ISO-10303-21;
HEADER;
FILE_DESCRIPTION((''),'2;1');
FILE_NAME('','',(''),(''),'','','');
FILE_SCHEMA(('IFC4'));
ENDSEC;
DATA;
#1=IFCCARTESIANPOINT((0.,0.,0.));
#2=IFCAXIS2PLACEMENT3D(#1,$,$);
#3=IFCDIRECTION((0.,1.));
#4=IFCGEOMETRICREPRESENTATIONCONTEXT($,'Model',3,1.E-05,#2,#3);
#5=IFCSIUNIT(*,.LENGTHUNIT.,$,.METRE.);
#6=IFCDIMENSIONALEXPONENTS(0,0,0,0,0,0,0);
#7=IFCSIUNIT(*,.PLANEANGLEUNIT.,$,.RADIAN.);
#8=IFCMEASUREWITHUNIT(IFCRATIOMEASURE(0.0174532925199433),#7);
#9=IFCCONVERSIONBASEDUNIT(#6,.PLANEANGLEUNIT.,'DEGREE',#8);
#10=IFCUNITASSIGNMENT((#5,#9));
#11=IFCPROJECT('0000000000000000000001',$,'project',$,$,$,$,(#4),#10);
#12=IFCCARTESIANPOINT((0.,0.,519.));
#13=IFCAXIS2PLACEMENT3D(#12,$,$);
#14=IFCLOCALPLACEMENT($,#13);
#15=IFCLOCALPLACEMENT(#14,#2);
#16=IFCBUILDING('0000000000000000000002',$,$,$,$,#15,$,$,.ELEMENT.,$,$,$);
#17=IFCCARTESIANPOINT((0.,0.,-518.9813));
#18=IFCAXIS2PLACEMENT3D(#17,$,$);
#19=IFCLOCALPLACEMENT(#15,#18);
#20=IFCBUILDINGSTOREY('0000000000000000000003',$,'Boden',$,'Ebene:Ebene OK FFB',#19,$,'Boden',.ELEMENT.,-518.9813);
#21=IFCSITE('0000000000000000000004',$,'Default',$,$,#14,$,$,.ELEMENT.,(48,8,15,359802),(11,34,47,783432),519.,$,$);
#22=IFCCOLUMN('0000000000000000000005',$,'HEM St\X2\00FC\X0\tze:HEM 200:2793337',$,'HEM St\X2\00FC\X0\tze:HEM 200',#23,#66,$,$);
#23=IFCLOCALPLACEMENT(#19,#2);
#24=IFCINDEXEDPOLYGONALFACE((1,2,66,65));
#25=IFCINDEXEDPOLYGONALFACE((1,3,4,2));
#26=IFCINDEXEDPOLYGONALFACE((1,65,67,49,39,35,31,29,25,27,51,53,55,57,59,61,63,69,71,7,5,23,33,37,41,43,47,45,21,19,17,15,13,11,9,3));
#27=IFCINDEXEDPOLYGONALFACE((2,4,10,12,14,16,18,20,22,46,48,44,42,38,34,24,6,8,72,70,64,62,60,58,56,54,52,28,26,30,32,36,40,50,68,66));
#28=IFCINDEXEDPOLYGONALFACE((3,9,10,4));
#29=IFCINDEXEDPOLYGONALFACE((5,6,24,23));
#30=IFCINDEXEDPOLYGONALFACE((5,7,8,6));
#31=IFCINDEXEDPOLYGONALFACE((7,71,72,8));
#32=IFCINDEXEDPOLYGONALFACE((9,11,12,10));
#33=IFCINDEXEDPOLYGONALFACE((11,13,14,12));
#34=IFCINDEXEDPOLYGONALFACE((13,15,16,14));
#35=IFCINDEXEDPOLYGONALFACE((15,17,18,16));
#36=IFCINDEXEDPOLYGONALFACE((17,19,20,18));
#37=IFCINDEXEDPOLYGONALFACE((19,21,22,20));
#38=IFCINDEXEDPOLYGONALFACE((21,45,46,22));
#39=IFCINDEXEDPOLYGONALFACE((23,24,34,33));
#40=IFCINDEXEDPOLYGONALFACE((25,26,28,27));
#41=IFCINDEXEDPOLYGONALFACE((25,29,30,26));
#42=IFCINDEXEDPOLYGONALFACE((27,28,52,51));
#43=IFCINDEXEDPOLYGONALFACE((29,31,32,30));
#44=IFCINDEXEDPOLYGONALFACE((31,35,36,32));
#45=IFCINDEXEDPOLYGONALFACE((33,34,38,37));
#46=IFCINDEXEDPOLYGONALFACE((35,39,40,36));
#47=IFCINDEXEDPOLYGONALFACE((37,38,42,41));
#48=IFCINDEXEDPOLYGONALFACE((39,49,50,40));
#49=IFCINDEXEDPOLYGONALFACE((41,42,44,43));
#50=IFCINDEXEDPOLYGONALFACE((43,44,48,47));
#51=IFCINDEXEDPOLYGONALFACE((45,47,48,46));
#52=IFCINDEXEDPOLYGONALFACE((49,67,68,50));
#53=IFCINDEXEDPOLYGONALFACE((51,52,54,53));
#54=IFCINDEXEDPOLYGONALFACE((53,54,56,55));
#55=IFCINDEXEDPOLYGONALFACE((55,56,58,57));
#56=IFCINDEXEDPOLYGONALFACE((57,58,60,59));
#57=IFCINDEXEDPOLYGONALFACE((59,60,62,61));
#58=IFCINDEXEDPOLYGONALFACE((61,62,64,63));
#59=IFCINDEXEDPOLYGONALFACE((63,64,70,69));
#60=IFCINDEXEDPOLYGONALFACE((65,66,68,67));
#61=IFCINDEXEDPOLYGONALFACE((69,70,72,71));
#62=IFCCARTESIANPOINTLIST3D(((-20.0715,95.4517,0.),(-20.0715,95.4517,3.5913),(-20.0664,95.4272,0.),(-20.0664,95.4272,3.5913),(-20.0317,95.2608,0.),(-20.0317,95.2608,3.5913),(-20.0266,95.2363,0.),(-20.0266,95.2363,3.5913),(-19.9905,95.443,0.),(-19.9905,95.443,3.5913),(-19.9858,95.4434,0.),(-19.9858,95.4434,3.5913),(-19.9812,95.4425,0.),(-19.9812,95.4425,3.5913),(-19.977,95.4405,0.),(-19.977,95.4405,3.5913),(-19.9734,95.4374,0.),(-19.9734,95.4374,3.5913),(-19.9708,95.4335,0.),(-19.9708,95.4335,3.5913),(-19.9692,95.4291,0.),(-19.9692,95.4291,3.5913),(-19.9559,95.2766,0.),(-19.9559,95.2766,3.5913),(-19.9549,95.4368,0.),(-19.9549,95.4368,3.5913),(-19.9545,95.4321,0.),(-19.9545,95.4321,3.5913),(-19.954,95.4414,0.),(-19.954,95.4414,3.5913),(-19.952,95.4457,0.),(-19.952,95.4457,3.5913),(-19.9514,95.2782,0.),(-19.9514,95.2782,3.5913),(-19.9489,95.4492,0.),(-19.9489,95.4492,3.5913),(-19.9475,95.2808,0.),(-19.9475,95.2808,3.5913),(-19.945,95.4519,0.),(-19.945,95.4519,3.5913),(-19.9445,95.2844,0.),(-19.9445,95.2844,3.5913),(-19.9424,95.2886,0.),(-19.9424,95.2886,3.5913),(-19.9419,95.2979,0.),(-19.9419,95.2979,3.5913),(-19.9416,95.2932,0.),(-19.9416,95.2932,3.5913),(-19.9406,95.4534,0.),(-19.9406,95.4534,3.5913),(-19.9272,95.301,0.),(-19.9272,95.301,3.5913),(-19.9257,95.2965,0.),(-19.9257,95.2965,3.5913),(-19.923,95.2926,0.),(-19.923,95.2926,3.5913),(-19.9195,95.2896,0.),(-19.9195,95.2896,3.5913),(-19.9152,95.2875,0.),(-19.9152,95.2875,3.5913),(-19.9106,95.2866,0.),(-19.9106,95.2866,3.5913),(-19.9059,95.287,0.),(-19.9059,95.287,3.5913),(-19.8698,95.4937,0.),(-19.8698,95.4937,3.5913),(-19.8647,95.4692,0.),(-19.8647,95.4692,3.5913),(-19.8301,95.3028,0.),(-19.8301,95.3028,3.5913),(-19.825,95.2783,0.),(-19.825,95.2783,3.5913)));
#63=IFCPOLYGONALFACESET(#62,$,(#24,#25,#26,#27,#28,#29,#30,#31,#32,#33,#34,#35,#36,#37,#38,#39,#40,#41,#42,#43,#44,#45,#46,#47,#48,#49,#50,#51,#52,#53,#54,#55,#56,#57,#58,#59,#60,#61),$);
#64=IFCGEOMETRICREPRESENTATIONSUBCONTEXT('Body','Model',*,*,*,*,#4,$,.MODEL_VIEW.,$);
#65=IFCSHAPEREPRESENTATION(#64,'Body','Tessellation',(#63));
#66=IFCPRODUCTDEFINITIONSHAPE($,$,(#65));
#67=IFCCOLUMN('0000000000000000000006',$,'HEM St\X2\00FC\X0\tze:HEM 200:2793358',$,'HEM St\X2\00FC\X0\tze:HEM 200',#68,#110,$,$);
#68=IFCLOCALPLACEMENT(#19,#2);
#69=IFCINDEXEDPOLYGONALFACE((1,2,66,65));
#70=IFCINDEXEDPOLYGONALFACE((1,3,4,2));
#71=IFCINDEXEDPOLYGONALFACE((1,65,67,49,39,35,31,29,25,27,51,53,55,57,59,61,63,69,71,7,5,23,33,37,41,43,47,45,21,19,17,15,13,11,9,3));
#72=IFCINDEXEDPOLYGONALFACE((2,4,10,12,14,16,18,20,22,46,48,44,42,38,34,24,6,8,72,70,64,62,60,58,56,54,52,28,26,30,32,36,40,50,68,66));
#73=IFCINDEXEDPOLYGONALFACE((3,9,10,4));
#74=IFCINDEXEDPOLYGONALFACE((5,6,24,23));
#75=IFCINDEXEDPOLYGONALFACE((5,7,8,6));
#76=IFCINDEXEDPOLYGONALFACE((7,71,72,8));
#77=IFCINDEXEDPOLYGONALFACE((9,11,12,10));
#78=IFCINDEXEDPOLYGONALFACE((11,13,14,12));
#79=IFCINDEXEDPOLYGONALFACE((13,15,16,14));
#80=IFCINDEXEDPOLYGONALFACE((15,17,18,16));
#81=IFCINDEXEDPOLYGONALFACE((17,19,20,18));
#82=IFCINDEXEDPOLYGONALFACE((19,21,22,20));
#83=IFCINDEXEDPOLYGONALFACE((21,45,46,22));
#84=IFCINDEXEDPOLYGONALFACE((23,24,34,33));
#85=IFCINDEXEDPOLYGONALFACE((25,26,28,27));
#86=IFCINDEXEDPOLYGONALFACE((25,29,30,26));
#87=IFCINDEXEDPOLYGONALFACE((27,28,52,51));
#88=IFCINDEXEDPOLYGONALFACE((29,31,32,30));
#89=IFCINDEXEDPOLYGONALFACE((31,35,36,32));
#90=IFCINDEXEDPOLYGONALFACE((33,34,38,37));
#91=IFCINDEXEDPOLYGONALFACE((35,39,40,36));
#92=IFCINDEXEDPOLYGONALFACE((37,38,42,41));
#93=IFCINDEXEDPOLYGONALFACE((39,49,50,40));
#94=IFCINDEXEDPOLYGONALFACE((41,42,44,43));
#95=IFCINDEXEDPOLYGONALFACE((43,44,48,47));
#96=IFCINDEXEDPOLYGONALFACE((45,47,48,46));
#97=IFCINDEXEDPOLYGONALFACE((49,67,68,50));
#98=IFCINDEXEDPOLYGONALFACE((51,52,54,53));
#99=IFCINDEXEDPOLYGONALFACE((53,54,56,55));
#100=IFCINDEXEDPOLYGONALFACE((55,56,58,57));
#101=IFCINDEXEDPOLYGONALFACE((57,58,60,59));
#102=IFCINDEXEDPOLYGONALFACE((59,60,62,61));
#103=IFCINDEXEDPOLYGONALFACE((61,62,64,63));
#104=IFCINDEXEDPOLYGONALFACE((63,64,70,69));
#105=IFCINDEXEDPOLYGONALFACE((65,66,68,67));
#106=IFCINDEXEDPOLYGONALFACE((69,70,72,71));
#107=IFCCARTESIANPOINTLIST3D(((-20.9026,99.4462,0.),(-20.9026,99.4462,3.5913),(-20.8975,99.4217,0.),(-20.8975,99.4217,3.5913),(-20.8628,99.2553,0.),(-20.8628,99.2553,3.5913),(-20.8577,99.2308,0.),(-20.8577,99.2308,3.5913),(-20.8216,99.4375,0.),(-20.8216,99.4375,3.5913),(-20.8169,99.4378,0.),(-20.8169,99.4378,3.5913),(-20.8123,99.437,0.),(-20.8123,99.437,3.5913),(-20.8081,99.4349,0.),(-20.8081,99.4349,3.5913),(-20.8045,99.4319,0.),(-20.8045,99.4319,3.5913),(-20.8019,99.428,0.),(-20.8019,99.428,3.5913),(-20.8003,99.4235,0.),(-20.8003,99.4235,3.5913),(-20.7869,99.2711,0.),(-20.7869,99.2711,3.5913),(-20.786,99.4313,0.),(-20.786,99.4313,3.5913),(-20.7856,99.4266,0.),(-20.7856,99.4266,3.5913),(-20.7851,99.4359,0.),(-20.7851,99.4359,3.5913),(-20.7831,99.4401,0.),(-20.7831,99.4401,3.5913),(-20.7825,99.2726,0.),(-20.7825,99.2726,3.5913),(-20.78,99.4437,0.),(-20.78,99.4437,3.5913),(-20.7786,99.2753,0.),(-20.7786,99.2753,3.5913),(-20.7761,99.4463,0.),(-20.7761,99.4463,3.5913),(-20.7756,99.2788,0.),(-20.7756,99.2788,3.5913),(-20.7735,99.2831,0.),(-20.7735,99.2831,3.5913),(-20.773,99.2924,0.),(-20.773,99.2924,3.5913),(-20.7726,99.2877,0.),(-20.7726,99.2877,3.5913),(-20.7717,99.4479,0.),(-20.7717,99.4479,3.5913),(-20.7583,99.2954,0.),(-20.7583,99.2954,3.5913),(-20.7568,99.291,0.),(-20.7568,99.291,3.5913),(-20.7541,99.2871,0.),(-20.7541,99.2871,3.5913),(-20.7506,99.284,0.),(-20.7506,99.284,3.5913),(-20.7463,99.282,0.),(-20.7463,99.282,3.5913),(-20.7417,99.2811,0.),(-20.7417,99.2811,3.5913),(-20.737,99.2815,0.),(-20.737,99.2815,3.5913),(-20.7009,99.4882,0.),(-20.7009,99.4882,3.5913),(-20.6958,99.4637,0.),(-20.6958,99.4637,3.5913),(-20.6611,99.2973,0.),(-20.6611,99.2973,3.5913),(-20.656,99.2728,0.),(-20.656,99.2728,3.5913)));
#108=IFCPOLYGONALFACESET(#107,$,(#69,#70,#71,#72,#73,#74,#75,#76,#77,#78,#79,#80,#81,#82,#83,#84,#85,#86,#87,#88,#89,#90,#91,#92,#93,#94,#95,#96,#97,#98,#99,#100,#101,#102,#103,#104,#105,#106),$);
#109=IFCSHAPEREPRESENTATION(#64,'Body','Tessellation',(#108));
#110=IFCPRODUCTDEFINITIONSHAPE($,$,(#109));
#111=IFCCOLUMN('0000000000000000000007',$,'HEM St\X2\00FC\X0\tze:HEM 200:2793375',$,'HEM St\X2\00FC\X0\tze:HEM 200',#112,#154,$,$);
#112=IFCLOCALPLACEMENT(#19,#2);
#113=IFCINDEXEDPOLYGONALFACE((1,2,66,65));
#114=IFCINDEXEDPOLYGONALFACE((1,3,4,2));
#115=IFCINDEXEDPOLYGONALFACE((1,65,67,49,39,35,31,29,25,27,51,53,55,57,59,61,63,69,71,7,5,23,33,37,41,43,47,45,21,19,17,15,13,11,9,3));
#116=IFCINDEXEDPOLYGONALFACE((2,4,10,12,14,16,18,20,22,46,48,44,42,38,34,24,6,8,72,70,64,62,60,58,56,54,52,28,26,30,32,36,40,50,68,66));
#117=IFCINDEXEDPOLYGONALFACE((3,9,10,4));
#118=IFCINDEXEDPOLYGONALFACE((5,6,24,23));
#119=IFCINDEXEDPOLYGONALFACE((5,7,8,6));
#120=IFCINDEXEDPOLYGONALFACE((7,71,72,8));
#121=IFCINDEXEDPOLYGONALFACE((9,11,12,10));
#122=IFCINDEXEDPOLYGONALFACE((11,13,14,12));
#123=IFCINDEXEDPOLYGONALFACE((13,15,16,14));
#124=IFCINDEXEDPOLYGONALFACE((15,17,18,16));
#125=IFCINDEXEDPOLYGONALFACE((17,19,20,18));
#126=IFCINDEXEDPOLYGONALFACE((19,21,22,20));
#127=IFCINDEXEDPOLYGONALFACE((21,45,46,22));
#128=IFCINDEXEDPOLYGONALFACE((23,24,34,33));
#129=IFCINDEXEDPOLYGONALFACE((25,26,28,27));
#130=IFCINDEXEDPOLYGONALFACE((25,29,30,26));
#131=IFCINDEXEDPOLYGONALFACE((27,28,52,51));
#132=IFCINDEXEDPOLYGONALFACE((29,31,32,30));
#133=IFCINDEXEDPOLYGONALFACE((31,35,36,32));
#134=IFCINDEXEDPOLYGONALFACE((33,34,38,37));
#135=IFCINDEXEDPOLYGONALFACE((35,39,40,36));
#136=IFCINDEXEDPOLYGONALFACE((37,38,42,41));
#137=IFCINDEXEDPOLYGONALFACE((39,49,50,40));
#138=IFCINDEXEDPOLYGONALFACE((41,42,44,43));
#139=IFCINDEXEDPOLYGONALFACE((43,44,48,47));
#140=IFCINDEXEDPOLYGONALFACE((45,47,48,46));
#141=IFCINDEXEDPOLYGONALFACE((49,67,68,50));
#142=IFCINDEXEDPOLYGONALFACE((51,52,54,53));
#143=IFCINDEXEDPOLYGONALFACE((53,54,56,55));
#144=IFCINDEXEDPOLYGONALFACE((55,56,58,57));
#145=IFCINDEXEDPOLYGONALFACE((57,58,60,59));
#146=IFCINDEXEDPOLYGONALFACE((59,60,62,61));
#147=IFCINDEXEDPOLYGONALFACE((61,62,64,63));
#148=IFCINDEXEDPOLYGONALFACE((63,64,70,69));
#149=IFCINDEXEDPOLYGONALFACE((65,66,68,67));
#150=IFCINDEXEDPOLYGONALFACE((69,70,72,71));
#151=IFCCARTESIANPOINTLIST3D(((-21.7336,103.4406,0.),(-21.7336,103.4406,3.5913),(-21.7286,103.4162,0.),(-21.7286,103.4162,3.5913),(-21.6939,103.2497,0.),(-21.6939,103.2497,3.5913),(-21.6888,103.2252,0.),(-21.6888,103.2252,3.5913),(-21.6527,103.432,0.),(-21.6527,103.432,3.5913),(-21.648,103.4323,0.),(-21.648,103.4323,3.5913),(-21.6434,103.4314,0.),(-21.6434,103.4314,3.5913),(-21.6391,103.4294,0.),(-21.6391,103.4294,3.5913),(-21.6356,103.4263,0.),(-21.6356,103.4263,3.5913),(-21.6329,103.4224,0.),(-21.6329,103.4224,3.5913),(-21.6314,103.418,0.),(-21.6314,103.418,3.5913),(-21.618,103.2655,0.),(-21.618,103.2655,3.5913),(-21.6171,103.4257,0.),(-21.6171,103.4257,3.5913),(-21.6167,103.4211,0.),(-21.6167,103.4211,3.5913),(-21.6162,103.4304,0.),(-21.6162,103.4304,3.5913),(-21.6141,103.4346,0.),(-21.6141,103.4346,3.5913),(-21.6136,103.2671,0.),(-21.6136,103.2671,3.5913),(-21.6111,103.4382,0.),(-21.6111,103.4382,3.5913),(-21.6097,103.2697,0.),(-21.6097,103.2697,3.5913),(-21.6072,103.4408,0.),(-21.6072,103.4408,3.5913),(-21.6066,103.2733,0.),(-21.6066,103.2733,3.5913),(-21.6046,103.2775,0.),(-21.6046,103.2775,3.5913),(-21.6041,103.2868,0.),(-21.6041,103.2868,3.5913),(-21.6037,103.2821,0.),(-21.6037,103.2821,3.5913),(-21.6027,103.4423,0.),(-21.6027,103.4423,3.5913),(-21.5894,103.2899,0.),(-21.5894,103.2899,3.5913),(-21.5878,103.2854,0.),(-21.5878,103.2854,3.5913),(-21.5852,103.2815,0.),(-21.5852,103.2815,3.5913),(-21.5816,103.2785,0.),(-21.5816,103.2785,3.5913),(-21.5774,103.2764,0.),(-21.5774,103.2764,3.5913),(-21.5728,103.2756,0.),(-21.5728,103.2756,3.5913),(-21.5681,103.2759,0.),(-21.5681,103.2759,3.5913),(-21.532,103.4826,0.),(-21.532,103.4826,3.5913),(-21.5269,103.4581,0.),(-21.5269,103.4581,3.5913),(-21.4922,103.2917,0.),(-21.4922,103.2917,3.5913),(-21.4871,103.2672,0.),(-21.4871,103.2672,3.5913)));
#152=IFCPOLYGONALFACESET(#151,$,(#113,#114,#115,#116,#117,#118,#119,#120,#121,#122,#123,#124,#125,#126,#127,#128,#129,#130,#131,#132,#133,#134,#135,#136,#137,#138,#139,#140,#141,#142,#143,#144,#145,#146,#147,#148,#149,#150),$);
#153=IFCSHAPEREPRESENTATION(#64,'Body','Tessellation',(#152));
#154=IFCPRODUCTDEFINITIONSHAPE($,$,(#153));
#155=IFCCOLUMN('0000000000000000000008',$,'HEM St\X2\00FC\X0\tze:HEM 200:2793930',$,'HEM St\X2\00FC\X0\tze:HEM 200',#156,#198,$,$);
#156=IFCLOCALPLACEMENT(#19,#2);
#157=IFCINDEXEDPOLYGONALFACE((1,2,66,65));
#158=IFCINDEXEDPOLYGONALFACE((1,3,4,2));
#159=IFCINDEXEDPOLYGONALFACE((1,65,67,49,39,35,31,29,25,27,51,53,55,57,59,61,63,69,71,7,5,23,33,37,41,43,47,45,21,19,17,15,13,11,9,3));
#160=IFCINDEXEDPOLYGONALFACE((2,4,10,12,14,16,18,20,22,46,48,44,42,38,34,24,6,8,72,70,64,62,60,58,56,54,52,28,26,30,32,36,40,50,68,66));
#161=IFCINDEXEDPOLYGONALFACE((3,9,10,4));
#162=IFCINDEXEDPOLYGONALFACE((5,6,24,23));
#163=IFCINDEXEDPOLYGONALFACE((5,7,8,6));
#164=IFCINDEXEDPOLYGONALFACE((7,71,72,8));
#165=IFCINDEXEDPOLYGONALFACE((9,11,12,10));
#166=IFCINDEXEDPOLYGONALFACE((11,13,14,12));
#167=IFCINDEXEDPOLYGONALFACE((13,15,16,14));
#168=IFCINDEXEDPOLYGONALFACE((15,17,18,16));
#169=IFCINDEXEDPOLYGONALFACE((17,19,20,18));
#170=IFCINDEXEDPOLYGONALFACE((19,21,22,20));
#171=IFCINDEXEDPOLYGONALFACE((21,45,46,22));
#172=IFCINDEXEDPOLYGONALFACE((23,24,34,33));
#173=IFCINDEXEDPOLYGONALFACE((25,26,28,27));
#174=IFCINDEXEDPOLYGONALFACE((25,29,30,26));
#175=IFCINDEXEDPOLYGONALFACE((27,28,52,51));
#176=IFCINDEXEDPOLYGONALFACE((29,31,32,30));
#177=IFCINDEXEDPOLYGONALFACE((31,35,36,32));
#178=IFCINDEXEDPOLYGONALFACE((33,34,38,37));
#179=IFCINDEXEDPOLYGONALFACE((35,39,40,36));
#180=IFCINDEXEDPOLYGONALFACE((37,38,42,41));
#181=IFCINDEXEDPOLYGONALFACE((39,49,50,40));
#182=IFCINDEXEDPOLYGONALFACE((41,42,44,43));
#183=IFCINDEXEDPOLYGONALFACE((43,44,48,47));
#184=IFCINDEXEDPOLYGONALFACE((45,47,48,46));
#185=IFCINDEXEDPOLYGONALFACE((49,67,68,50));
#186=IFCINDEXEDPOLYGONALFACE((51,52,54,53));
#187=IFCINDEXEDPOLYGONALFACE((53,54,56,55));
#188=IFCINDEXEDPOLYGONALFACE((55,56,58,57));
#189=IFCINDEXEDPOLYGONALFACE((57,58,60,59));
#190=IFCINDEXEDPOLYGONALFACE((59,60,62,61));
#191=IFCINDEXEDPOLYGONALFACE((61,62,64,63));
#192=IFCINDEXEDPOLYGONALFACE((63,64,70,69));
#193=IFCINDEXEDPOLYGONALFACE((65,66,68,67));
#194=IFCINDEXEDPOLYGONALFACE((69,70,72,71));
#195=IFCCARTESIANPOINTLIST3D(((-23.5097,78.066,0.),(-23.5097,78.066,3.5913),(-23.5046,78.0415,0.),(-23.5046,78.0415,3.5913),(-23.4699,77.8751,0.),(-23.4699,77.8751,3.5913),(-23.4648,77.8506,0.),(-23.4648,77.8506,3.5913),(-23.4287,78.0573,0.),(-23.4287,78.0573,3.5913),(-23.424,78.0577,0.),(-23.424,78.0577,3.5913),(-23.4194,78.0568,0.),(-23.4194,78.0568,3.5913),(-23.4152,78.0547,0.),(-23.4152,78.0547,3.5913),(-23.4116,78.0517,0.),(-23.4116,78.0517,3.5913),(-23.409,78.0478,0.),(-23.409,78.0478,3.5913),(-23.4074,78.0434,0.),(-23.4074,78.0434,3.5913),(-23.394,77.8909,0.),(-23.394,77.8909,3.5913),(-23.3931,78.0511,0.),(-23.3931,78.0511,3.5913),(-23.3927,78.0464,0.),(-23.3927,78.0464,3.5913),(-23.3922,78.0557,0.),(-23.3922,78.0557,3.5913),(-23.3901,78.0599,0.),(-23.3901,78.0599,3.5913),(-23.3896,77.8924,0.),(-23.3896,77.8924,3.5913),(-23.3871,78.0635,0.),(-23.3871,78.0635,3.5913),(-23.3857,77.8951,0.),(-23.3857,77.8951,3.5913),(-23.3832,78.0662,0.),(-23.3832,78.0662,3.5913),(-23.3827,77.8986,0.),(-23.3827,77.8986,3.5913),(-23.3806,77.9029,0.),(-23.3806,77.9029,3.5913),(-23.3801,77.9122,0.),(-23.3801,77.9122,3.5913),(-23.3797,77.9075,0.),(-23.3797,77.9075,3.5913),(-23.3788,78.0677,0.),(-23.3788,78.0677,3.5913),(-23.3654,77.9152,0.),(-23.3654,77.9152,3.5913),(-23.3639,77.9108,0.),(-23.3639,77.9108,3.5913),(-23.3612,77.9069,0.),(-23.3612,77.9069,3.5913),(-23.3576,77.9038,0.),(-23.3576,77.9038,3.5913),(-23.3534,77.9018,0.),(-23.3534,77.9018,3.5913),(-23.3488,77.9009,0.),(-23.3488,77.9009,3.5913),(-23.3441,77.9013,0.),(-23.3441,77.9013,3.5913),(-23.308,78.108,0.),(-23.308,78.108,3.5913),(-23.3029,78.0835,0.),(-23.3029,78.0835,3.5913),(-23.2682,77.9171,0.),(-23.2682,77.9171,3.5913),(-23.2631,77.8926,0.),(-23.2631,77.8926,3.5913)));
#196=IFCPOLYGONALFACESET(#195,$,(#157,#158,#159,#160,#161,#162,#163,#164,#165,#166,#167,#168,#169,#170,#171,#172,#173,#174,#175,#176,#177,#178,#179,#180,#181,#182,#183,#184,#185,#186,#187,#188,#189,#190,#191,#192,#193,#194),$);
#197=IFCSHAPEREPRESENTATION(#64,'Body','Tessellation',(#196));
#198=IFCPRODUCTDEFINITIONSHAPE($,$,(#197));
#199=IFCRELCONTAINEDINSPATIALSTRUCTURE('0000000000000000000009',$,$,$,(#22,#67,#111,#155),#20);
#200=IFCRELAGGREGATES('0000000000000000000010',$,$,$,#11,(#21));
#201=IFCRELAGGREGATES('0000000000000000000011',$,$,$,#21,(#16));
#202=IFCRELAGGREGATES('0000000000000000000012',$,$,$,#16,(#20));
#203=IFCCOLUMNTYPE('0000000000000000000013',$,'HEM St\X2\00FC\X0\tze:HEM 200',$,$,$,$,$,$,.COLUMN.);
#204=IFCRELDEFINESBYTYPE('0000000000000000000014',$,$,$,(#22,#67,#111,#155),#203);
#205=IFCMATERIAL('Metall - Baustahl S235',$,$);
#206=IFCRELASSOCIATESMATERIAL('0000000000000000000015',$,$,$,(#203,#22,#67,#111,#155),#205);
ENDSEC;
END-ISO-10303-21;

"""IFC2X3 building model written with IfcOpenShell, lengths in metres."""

from ifc_helpers import new_model, entity, si_unit, converted_unit, direction, frame, frame_2d, origin, place, context, subcontext, project, spatial, polyline, circle_curve, parameter, trimmed, segment, composite_curve, outline, extrude, source, transform, mapped, material, type_object, type_shapes, element, save


model = new_model("IFC2X3")

# Units and contexts
model_context = context("Model", 3, precision=1e-05, world=origin(), true_north=direction((0.0, 1.0)))
body_context = subcontext(model_context, "Body", "Model", "MODEL_VIEW")
ifc_project = project(units=[si_unit("LENGTHUNIT", "METRE"), converted_unit("PLANEANGLEUNIT", "DEGREE", entity("IfcRatioMeasure", 0.0174532925199433), si_unit("PLANEANGLEUNIT", "RADIAN"), dimensions=[0, 0, 0, 0, 0, 0, 0])], contexts=[model_context])

# Site, building, storey
site_placement = place(None, frame((0.0, 0.0, 519.0)))
site = spatial("IfcSite", under=ifc_project, at=site_placement, Name="Default", CompositionType="ELEMENT", RefLatitude=(48, 8, 15, 359802), RefLongitude=(11, 34, 47, 783432), RefElevation=519.0)
building_placement = place(site_placement, origin())
building = spatial("IfcBuilding", under=site, at=building_placement, CompositionType="ELEMENT")
storey_placement = place(building_placement, frame((0.0, 0.0, -518.9813)))
storey = spatial("IfcBuildingStorey", under=building, at=storey_placement, Name="Boden", ObjectType="Ebene:Ebene OK FFB", LongName="Boden", CompositionType="ELEMENT", Elevation=-518.9813)

# Columns
ifc_material = material(Name="Metall - Baustahl S235")
column_type = type_object("IfcColumnType", Name="HEM Stütze:HEM 200", PredefinedType="COLUMN", material=ifc_material)
shared_shape = source(origin(), body_context, "Body", "SweptSolid", [
    extrude(outline(composite_curve([segment(polyline([(0.085, -0.103), (0.11, -0.103)]), True, "CONTINUOUS"), segment(polyline([(0.11, -0.103), (0.11, 0.103)]), True, "CONTINUOUS"), segment(polyline([(0.11, 0.103), (0.085, 0.103)]), True, "CONTINUOUS"), segment(polyline([(0.085, 0.103), (0.085, 0.0255)]), True, "CONTINUOUS"), segment(trimmed(circle_curve(frame_2d((0.067, 0.0255), x_axis=(1.0, 0.0)), 0.018), [parameter(270.0)], [parameter(0.0)], True, "PARAMETER"), False, "CONTINUOUS"), segment(polyline([(0.067, 0.0075), (-0.067, 0.0075)]), True, "CONTINUOUS"), segment(trimmed(circle_curve(frame_2d((-0.067, 0.0255), x_axis=(0.0, -1.0)), 0.018), [parameter(270.0)], [parameter(0.0)], True, "PARAMETER"), False, "CONTINUOUS"), segment(polyline([(-0.085, 0.0255), (-0.085, 0.103)]), True, "CONTINUOUS"), segment(polyline([(-0.085, 0.103), (-0.11, 0.103)]), True, "CONTINUOUS"), segment(polyline([(-0.11, 0.103), (-0.11, -0.103)]), True, "CONTINUOUS"), segment(polyline([(-0.11, -0.103), (-0.085, -0.103)]), True, "CONTINUOUS"), segment(polyline([(-0.085, -0.103), (-0.085, -0.0255)]), True, "CONTINUOUS"), segment(trimmed(circle_curve(frame_2d((-0.067, -0.0255), x_axis=(-1.0, 0.0)), 0.018), [parameter(270.0)], [parameter(0.0)], True, "PARAMETER"), False, "CONTINUOUS"), segment(polyline([(-0.067, -0.0075), (0.067, -0.0075)]), True, "CONTINUOUS"), segment(trimmed(circle_curve(frame_2d((0.067, -0.0255), x_axis=(0.0, 1.0)), 0.018), [parameter(270.0)], [parameter(0.0)], True, "PARAMETER"), False, "CONTINUOUS"), segment(polyline([(0.085, -0.0255), (0.085, -0.103)]), True, "CONTINUOUS")], self_intersect=False)), frame((0.0, 0.0, -518.9813), z_axis=(0.0, 0.0, 1.0), x_axis=(0.0, -1.0, 0.0)), (0.0, 0.0, 1.0), 3.5913),
])
type_shapes(column_type, [shared_shape])
for number, where, z_axis, x_axis, name in (
    (1, (-19.9482, 95.365, 518.9813), (0.0, 0.0, 1.0), (0.979008, 0.20382, 0.0), "HEM Stütze:HEM 200:2793337"),
    (2, (-20.7793, 99.3595, 518.9813), (0.0, 0.0, 1.0), (0.979008, 0.20382, 0.0), "HEM Stütze:HEM 200:2793358"),
    (3, (-21.6104, 103.3539, 518.9813), (0.0, 0.0, 1.0), (0.979008, 0.20382, 0.0), "HEM Stütze:HEM 200:2793375"),
    (4, (-23.3864, 77.9793, 518.9813), (0.0, 0.0, 1.0), (0.979008, 0.20382, 0.0), "HEM Stütze:HEM 200:2793930"),
):
    element("IfcColumn", number, at=place(storey_placement, frame(where, z_axis=z_axis, x_axis=x_axis)), inside=storey, type_object=column_type, material=ifc_material, Name=name, ObjectType="HEM Stütze:HEM 200", context=body_context, shape_type="MappedRepresentation", body=[
        mapped(shared_shape, transform((0.0, 0.0, 0.0), scale=1.0)),
    ])

save(model, "model.ifc")
